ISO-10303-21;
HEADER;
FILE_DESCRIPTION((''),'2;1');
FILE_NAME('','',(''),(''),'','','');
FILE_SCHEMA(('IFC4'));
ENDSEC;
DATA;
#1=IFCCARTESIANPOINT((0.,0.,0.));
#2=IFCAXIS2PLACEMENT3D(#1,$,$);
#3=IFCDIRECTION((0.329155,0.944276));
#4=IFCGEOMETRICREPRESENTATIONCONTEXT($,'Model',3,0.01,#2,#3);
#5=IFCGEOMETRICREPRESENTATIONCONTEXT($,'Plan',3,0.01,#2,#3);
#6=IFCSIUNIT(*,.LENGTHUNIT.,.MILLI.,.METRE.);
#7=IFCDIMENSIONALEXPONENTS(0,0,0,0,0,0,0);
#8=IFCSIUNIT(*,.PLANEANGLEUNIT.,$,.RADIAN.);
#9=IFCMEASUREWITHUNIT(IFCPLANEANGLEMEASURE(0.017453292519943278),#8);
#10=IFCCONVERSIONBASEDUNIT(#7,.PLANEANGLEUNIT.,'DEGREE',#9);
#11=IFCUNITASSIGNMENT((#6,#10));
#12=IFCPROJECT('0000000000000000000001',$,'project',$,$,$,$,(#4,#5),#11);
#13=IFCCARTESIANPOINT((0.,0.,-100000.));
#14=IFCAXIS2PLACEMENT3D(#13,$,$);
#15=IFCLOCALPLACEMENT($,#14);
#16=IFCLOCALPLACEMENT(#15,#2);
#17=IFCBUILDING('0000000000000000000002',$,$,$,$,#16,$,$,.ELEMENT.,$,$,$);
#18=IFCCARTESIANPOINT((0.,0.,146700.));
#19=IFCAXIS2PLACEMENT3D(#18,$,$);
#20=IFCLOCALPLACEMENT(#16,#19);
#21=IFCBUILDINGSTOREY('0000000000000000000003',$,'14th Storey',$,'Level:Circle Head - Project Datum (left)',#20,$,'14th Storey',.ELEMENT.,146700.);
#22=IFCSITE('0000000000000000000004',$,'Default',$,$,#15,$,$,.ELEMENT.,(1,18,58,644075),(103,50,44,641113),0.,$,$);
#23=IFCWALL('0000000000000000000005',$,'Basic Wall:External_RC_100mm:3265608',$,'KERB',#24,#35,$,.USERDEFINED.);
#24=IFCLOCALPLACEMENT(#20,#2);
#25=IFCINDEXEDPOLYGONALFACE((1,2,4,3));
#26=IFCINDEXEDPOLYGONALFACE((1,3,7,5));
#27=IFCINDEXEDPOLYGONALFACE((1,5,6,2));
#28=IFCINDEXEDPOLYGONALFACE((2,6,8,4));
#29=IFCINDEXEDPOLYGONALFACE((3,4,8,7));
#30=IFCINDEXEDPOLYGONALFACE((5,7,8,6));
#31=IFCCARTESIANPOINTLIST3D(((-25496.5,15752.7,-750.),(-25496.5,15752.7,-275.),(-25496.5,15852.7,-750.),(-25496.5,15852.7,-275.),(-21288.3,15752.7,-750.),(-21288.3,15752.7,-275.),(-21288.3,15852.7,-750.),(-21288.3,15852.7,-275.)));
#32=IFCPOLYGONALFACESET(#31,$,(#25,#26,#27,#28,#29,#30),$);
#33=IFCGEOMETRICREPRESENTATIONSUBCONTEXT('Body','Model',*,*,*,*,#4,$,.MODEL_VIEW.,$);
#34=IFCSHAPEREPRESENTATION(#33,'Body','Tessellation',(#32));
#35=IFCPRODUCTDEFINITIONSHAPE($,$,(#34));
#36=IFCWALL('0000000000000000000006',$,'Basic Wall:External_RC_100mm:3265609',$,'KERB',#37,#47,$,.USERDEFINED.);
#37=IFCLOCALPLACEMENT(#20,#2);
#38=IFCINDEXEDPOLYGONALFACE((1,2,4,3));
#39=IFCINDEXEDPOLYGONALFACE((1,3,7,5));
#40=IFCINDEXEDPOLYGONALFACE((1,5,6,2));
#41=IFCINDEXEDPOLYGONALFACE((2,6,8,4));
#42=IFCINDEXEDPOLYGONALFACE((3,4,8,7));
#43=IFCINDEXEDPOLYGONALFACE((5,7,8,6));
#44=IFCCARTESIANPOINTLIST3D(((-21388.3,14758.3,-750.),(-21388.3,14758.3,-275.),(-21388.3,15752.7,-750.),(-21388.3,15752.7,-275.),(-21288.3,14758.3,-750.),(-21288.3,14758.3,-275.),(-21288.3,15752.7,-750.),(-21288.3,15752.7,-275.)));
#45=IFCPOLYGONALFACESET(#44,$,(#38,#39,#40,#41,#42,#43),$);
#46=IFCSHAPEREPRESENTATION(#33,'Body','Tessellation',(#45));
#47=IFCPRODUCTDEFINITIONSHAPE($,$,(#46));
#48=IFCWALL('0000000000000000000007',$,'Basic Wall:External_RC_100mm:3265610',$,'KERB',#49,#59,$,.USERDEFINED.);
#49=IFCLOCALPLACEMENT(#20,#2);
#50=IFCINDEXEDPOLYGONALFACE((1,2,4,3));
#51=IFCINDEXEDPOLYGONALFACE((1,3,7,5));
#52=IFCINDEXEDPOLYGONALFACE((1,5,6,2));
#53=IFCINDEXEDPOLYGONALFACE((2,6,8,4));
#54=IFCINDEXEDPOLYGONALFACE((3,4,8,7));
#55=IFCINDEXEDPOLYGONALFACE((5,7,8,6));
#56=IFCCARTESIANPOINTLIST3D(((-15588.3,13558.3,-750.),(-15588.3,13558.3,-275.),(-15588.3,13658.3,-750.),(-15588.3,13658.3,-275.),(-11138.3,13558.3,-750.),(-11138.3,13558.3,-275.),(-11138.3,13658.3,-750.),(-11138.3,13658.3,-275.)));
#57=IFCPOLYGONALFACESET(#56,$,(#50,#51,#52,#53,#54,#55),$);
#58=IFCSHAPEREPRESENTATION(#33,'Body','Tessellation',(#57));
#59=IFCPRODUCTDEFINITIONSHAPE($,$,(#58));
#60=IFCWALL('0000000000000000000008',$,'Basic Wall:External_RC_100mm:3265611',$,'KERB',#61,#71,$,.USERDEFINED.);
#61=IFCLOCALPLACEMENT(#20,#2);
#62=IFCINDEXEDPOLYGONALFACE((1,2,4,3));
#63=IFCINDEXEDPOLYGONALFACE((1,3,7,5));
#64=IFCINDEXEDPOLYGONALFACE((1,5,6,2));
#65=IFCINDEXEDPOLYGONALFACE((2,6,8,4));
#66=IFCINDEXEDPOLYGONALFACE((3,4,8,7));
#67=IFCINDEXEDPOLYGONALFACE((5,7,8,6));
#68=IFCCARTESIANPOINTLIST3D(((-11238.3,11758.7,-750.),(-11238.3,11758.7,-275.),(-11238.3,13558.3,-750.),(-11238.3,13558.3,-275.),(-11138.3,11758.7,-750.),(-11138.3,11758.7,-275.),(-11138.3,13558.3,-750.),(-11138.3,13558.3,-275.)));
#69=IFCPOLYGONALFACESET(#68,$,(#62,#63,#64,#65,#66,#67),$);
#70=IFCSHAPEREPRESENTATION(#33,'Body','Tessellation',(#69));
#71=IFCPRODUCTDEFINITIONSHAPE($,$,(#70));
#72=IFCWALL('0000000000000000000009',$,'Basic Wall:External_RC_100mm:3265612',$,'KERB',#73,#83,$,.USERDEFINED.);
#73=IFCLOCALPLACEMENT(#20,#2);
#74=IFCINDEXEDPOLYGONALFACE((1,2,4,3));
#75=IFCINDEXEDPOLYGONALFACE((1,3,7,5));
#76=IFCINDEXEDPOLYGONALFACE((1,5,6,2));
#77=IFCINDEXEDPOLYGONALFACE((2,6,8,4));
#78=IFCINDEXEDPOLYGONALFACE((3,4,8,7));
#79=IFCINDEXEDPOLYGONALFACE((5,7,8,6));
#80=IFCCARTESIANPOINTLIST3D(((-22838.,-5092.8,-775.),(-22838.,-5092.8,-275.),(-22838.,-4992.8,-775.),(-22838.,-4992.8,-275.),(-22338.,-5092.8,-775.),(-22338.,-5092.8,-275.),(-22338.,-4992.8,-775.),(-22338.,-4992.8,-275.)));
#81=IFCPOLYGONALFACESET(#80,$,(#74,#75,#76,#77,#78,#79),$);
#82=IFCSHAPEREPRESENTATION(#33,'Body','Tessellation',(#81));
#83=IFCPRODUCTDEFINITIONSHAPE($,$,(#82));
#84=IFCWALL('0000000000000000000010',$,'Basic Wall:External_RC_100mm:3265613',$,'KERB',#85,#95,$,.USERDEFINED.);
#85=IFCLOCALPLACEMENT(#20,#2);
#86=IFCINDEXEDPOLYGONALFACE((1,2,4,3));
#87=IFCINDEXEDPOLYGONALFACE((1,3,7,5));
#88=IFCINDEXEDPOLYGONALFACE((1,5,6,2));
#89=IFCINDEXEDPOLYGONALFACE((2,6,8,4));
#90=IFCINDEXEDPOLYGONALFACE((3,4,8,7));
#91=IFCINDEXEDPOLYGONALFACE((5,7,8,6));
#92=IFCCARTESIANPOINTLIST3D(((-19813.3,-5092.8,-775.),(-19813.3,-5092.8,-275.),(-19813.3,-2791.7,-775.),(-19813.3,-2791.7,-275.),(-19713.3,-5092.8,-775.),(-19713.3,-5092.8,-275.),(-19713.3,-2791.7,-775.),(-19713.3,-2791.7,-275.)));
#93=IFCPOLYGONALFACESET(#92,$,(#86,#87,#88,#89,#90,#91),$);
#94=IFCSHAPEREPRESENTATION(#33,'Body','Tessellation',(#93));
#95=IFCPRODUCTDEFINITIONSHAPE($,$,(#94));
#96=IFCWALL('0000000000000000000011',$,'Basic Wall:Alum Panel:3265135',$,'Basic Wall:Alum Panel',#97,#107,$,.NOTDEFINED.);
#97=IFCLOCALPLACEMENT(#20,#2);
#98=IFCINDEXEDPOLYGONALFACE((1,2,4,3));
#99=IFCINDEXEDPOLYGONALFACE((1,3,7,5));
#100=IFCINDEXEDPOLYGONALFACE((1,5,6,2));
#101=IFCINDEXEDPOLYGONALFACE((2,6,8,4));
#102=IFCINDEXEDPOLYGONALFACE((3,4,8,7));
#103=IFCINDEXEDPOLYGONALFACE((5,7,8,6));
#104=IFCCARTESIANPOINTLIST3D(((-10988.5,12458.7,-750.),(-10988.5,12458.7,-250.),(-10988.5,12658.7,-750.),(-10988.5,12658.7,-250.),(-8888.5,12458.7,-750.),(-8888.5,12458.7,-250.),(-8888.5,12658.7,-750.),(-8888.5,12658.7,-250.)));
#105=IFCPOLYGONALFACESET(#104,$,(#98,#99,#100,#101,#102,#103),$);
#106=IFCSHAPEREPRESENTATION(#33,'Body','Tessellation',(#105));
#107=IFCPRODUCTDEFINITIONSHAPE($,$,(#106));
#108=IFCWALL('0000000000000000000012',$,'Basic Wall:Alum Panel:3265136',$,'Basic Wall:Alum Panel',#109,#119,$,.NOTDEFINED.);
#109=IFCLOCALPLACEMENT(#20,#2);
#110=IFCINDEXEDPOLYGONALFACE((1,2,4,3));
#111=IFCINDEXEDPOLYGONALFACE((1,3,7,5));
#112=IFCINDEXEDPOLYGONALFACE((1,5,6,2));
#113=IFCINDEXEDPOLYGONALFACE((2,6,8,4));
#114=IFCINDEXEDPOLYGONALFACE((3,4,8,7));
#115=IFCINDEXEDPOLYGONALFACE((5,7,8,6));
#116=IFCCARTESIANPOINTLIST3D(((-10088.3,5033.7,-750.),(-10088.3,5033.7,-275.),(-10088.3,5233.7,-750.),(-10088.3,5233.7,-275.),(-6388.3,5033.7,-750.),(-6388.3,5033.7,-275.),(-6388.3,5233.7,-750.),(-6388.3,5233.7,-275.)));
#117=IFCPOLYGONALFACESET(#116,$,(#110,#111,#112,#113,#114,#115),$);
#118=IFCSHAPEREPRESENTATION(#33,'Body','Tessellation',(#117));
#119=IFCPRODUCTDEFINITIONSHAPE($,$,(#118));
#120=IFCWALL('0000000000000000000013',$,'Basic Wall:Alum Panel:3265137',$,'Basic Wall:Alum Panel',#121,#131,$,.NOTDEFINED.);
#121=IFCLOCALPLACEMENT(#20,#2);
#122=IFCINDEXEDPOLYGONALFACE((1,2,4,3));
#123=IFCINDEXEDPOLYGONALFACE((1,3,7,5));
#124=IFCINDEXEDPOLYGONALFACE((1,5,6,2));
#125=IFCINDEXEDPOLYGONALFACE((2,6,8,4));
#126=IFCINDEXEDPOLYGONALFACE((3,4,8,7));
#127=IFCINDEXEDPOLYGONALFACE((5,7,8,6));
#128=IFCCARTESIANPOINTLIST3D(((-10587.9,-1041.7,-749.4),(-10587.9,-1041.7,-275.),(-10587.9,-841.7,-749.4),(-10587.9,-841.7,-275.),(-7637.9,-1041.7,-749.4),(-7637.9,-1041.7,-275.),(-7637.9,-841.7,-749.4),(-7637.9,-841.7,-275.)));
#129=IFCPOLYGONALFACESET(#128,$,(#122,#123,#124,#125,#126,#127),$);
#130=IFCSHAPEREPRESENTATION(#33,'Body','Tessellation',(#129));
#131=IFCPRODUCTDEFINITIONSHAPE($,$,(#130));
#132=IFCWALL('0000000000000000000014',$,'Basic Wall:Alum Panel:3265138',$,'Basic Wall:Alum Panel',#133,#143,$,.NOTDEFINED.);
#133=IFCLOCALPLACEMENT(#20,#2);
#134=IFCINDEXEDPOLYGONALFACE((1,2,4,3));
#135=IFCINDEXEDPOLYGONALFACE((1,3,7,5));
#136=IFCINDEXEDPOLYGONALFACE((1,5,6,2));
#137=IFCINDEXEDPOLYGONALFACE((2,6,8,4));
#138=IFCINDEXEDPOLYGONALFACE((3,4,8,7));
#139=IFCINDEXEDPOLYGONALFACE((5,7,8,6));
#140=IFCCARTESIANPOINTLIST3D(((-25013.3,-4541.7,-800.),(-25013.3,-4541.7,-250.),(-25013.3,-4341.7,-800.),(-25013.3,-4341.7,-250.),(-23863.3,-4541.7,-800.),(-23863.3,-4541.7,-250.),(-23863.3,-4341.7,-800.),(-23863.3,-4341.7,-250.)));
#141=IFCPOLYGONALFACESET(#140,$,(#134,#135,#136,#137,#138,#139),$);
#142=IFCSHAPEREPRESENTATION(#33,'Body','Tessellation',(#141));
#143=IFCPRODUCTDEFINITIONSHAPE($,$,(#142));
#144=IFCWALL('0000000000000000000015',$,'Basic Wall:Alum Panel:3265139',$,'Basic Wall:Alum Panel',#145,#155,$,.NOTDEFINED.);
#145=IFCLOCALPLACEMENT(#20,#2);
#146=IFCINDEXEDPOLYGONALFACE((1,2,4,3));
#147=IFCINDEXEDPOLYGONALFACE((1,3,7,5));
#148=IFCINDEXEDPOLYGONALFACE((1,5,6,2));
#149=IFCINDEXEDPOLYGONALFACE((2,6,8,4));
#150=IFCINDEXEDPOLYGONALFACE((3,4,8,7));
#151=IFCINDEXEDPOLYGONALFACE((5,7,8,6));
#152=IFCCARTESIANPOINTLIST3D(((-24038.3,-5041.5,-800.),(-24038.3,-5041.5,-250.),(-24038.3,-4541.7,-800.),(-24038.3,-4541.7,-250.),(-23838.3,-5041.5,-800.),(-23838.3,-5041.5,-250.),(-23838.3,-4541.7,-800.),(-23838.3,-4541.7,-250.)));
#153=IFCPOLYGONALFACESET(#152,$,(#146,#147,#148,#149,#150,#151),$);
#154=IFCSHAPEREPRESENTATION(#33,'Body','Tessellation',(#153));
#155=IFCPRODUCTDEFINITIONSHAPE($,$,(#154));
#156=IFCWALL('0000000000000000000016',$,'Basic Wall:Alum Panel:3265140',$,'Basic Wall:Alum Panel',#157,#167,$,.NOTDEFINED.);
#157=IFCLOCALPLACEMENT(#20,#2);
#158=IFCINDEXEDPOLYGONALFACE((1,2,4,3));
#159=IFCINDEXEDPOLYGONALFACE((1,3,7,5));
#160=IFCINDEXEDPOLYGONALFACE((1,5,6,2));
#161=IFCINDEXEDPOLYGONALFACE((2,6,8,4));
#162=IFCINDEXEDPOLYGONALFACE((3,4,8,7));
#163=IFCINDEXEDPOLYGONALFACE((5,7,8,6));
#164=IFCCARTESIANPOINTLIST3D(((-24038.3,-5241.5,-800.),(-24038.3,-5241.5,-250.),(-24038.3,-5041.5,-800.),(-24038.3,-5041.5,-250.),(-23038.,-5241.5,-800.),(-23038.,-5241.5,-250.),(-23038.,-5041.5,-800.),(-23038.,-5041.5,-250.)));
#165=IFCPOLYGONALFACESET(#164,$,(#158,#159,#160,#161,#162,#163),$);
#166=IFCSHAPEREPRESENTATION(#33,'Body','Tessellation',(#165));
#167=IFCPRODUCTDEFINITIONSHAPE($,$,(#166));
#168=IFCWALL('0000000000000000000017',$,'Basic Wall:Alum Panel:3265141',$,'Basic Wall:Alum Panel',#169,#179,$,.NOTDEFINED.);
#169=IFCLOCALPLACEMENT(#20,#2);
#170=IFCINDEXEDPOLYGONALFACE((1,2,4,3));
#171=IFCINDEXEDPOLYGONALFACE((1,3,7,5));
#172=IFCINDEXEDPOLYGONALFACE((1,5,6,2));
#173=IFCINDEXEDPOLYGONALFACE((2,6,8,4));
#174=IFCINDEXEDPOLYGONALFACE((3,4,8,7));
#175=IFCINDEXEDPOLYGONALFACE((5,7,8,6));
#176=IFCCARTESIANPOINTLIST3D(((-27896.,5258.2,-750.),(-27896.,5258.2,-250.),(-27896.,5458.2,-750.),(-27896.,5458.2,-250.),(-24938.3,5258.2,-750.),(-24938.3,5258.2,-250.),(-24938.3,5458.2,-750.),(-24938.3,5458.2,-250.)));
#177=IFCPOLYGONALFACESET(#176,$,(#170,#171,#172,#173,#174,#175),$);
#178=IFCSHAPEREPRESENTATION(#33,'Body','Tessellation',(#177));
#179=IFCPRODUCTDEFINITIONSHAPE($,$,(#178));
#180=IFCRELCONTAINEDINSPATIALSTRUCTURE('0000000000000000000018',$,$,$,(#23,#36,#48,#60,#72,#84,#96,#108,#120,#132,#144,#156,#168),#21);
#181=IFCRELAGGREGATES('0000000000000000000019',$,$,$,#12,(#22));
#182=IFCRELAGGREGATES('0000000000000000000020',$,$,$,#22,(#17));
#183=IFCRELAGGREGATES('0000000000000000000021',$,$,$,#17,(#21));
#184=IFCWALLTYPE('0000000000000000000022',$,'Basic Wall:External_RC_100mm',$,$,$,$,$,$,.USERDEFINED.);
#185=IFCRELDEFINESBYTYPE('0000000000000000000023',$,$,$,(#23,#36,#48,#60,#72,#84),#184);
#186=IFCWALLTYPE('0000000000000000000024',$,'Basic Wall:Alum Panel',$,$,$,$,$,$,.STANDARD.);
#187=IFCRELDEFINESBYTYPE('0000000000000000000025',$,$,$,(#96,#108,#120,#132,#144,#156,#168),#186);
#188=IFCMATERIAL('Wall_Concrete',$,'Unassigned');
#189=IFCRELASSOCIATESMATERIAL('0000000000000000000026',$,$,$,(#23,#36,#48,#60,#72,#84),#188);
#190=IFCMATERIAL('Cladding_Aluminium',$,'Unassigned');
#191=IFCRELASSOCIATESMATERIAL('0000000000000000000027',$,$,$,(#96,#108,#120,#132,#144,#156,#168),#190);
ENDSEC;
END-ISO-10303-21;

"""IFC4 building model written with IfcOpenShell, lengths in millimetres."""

from ifc_helpers import new_model, entity, si_unit, converted_unit, direction, frame, origin, place, context, subcontext, project, spatial, indexed_curve, outline, extrude, material, type_object, element, save


model = new_model("IFC4")

# Units and contexts
model_context = context("Model", 3, precision=0.01, world=origin(), true_north=direction((0.329155, 0.944276)))
plan_context = context("Plan", 3, precision=0.01, world=origin(), true_north=direction((0.329155, 0.944276)))
body_context = subcontext(model_context, "Body", "Model", "MODEL_VIEW")
ifc_project = project(units=[si_unit("LENGTHUNIT", "METRE", prefix="MILLI"), converted_unit("PLANEANGLEUNIT", "DEGREE", entity("IfcPlaneAngleMeasure", 0.017453292519943278), si_unit("PLANEANGLEUNIT", "RADIAN"), dimensions=[0, 0, 0, 0, 0, 0, 0])], contexts=[model_context, plan_context])

# Site, building, storey
site_placement = place(None, frame((0.0, 0.0, -100000.0)))
site = spatial("IfcSite", under=ifc_project, at=site_placement, Name="Default", CompositionType="ELEMENT", RefLatitude=(1, 18, 58, 644075), RefLongitude=(103, 50, 44, 641113), RefElevation=0.0)
building_placement = place(site_placement, origin())
building = spatial("IfcBuilding", under=site, at=building_placement, CompositionType="ELEMENT")
storey_placement = place(building_placement, frame((0.0, 0.0, 146700.0)))
storey = spatial("IfcBuildingStorey", under=building, at=storey_placement, Name="14th Storey", ObjectType="Level:Circle Head - Project Datum (left)", LongName="14th Storey", CompositionType="ELEMENT", Elevation=146700.0)

# Shared definitions
ifc_material_1 = material(Name="Cladding_Aluminium", Category="Unassigned")

# Walls
ifc_material_2 = material(Name="Wall_Concrete", Category="Unassigned")
wall_type_1 = type_object("IfcWallType", Name="Basic Wall:External_RC_100mm", PredefinedType="USERDEFINED")
wall_1_placement = place(storey_placement, frame((-25496.5, 15802.7, -750.0)))
element("IfcWall", 1, at=wall_1_placement, inside=storey, type_object=wall_type_1, material=ifc_material_2, Name="Basic Wall:External_RC_100mm:3265608", ObjectType="KERB", PredefinedType="USERDEFINED", context=body_context, shape_type="SweptSolid", body=[
    extrude(outline(indexed_curve([(4208.2, 50.0), (0.0, 50.0), (0.0, -50.0), (4208.2, -50.0), (4208.2, 50.0)], self_intersect=False)), origin(), (0.0, 0.0, 1.0), 475.0),
])
wall_2_placement = place(storey_placement, frame((-21338.3, 14758.3, -750.0), z_axis=(0.0, 0.0, 1.0), x_axis=(0.0, 1.0, 0.0)))
element("IfcWall", 2, at=wall_2_placement, inside=storey, type_object=wall_type_1, material=ifc_material_2, Name="Basic Wall:External_RC_100mm:3265609", ObjectType="KERB", PredefinedType="USERDEFINED", context=body_context, shape_type="SweptSolid", body=[
    extrude(outline(indexed_curve([(994.5, 50.0), (0.0, 50.0), (0.0, -50.0), (994.5, -50.0), (994.5, 50.0)], self_intersect=False)), origin(), (0.0, 0.0, 1.0), 475.0),
])
wall_3_placement = place(storey_placement, frame((-15588.3, 13608.3, -750.0)))
element("IfcWall", 3, at=wall_3_placement, inside=storey, type_object=wall_type_1, material=ifc_material_2, Name="Basic Wall:External_RC_100mm:3265610", ObjectType="KERB", PredefinedType="USERDEFINED", context=body_context, shape_type="SweptSolid", body=[
    extrude(outline(indexed_curve([(4450.0, 50.0), (0.0, 50.0), (0.0, -50.0), (4450.0, -50.0), (4450.0, 50.0)], self_intersect=False)), origin(), (0.0, 0.0, 1.0), 475.0),
])
wall_4_placement = place(storey_placement, frame((-11188.3, 13558.3, -750.0), z_axis=(0.0, 0.0, 1.0), x_axis=(0.0, -1.0, 0.0)))
element("IfcWall", 4, at=wall_4_placement, inside=storey, type_object=wall_type_1, material=ifc_material_2, Name="Basic Wall:External_RC_100mm:3265611", ObjectType="KERB", PredefinedType="USERDEFINED", context=body_context, shape_type="SweptSolid", body=[
    extrude(outline(indexed_curve([(1799.6, 50.0), (0.0, 50.0), (0.0, -50.0), (1799.6, -50.0), (1799.6, 50.0)], self_intersect=False)), origin(), (0.0, 0.0, 1.0), 475.0),
])
wall_5_placement = place(storey_placement, frame((-22838.0, -5042.8, -775.0)))
element("IfcWall", 5, at=wall_5_placement, inside=storey, type_object=wall_type_1, material=ifc_material_2, Name="Basic Wall:External_RC_100mm:3265612", ObjectType="KERB", PredefinedType="USERDEFINED", context=body_context, shape_type="SweptSolid", body=[
    extrude(outline(indexed_curve([(500.0, 50.0), (0.0, 50.0), (0.0, -50.0), (500.0, -50.0), (500.0, 50.0)], self_intersect=False)), origin(), (0.0, 0.0, 1.0), 500.0),
])
wall_6_placement = place(storey_placement, frame((-19763.3, -5092.8, -775.0), z_axis=(0.0, 0.0, 1.0), x_axis=(0.0, 1.0, 0.0)))
element("IfcWall", 6, at=wall_6_placement, inside=storey, type_object=wall_type_1, material=ifc_material_2, Name="Basic Wall:External_RC_100mm:3265613", ObjectType="KERB", PredefinedType="USERDEFINED", context=body_context, shape_type="SweptSolid", body=[
    extrude(outline(indexed_curve([(2301.0, 50.0), (0.0, 50.0), (0.0, -50.0), (2301.0, -50.0), (2301.0, 50.0)], self_intersect=False)), origin(), (0.0, 0.0, 1.0), 500.0),
])
wall_type_2 = type_object("IfcWallType", Name="Basic Wall:Alum Panel", PredefinedType="STANDARD")
wall_7_placement = place(storey_placement, frame((-10988.5, 12558.7, -750.0)))
element("IfcWall", 7, at=wall_7_placement, inside=storey, type_object=wall_type_2, material=ifc_material_1, Name="Basic Wall:Alum Panel:3265135", ObjectType="Basic Wall:Alum Panel", PredefinedType="NOTDEFINED", context=body_context, shape_type="SweptSolid", body=[
    extrude(outline(indexed_curve([(2100.0, 100.0), (0.0, 100.0), (0.0, -100.0), (2100.0, -100.0), (2100.0, 100.0)], self_intersect=False)), origin(), (0.0, 0.0, 1.0), 500.0),
])
wall_8_placement = place(storey_placement, frame((-6388.3, 5133.7, -750.0), z_axis=(0.0, 0.0, 1.0), x_axis=(-1.0, 0.0, 0.0)))
element("IfcWall", 8, at=wall_8_placement, inside=storey, type_object=wall_type_2, material=ifc_material_1, Name="Basic Wall:Alum Panel:3265136", ObjectType="Basic Wall:Alum Panel", PredefinedType="NOTDEFINED", context=body_context, shape_type="SweptSolid", body=[
    extrude(outline(indexed_curve([(3700.0, 100.0), (0.0, 100.0), (0.0, -100.0), (3700.0, -100.0), (3700.0, 100.0)], self_intersect=False)), origin(), (0.0, 0.0, 1.0), 475.0),
])
wall_9_placement = place(storey_placement, frame((-7637.9, -941.7, -749.4), z_axis=(0.0, 0.0, 1.0), x_axis=(-1.0, 0.0, 0.0)))
element("IfcWall", 9, at=wall_9_placement, inside=storey, type_object=wall_type_2, material=ifc_material_1, Name="Basic Wall:Alum Panel:3265137", ObjectType="Basic Wall:Alum Panel", PredefinedType="NOTDEFINED", context=body_context, shape_type="SweptSolid", body=[
    extrude(outline(indexed_curve([(2950.0, 100.0), (0.0, 100.0), (0.0, -100.0), (2950.0, -100.0), (2950.0, 100.0)], self_intersect=False)), origin(), (0.0, 0.0, 1.0), 474.4),
])
wall_10_placement = place(storey_placement, frame((-25013.3, -4441.7, -800.0)))
element("IfcWall", 10, at=wall_10_placement, inside=storey, type_object=wall_type_2, material=ifc_material_1, Name="Basic Wall:Alum Panel:3265138", ObjectType="Basic Wall:Alum Panel", PredefinedType="NOTDEFINED", context=body_context, shape_type="SweptSolid", body=[
    extrude(outline(indexed_curve([(1150.0, 100.0), (0.0, 100.0), (0.0, -100.0), (1150.0, -100.0), (1150.0, 100.0)], self_intersect=False)), origin(), (0.0, 0.0, 1.0), 550.0),
])
wall_11_placement = place(storey_placement, frame((-23938.3, -4541.7, -800.0), z_axis=(0.0, 0.0, 1.0), x_axis=(0.0, -1.0, 0.0)))
element("IfcWall", 11, at=wall_11_placement, inside=storey, type_object=wall_type_2, material=ifc_material_1, Name="Basic Wall:Alum Panel:3265139", ObjectType="Basic Wall:Alum Panel", PredefinedType="NOTDEFINED", context=body_context, shape_type="SweptSolid", body=[
    extrude(outline(indexed_curve([(499.8, 100.0), (0.0, 100.0), (0.0, -100.0), (499.8, -100.0), (499.8, 100.0)], self_intersect=False)), origin(), (0.0, 0.0, 1.0), 550.0),
])
wall_12_placement = place(storey_placement, frame((-24038.3, -5141.5, -800.0)))
element("IfcWall", 12, at=wall_12_placement, inside=storey, type_object=wall_type_2, material=ifc_material_1, Name="Basic Wall:Alum Panel:3265140", ObjectType="Basic Wall:Alum Panel", PredefinedType="NOTDEFINED", context=body_context, shape_type="SweptSolid", body=[
    extrude(outline(indexed_curve([(1000.4, 100.0), (0.0, 100.0), (0.0, -100.0), (1000.4, -100.0), (1000.4, 100.0)], self_intersect=False)), origin(), (0.0, 0.0, 1.0), 550.0),
])
wall_13_placement = place(storey_placement, frame((-27896.0, 5358.2, -750.0)))
element("IfcWall", 13, at=wall_13_placement, inside=storey, type_object=wall_type_2, material=ifc_material_1, Name="Basic Wall:Alum Panel:3265141", ObjectType="Basic Wall:Alum Panel", PredefinedType="NOTDEFINED", context=body_context, shape_type="SweptSolid", body=[
    extrude(outline(indexed_curve([(2957.7, 100.0), (0.0, 100.0), (0.0, -100.0), (2957.7, -100.0), (2957.7, 100.0)], self_intersect=False)), origin(), (0.0, 0.0, 1.0), 500.0),
])

save(model, "model.ifc")
